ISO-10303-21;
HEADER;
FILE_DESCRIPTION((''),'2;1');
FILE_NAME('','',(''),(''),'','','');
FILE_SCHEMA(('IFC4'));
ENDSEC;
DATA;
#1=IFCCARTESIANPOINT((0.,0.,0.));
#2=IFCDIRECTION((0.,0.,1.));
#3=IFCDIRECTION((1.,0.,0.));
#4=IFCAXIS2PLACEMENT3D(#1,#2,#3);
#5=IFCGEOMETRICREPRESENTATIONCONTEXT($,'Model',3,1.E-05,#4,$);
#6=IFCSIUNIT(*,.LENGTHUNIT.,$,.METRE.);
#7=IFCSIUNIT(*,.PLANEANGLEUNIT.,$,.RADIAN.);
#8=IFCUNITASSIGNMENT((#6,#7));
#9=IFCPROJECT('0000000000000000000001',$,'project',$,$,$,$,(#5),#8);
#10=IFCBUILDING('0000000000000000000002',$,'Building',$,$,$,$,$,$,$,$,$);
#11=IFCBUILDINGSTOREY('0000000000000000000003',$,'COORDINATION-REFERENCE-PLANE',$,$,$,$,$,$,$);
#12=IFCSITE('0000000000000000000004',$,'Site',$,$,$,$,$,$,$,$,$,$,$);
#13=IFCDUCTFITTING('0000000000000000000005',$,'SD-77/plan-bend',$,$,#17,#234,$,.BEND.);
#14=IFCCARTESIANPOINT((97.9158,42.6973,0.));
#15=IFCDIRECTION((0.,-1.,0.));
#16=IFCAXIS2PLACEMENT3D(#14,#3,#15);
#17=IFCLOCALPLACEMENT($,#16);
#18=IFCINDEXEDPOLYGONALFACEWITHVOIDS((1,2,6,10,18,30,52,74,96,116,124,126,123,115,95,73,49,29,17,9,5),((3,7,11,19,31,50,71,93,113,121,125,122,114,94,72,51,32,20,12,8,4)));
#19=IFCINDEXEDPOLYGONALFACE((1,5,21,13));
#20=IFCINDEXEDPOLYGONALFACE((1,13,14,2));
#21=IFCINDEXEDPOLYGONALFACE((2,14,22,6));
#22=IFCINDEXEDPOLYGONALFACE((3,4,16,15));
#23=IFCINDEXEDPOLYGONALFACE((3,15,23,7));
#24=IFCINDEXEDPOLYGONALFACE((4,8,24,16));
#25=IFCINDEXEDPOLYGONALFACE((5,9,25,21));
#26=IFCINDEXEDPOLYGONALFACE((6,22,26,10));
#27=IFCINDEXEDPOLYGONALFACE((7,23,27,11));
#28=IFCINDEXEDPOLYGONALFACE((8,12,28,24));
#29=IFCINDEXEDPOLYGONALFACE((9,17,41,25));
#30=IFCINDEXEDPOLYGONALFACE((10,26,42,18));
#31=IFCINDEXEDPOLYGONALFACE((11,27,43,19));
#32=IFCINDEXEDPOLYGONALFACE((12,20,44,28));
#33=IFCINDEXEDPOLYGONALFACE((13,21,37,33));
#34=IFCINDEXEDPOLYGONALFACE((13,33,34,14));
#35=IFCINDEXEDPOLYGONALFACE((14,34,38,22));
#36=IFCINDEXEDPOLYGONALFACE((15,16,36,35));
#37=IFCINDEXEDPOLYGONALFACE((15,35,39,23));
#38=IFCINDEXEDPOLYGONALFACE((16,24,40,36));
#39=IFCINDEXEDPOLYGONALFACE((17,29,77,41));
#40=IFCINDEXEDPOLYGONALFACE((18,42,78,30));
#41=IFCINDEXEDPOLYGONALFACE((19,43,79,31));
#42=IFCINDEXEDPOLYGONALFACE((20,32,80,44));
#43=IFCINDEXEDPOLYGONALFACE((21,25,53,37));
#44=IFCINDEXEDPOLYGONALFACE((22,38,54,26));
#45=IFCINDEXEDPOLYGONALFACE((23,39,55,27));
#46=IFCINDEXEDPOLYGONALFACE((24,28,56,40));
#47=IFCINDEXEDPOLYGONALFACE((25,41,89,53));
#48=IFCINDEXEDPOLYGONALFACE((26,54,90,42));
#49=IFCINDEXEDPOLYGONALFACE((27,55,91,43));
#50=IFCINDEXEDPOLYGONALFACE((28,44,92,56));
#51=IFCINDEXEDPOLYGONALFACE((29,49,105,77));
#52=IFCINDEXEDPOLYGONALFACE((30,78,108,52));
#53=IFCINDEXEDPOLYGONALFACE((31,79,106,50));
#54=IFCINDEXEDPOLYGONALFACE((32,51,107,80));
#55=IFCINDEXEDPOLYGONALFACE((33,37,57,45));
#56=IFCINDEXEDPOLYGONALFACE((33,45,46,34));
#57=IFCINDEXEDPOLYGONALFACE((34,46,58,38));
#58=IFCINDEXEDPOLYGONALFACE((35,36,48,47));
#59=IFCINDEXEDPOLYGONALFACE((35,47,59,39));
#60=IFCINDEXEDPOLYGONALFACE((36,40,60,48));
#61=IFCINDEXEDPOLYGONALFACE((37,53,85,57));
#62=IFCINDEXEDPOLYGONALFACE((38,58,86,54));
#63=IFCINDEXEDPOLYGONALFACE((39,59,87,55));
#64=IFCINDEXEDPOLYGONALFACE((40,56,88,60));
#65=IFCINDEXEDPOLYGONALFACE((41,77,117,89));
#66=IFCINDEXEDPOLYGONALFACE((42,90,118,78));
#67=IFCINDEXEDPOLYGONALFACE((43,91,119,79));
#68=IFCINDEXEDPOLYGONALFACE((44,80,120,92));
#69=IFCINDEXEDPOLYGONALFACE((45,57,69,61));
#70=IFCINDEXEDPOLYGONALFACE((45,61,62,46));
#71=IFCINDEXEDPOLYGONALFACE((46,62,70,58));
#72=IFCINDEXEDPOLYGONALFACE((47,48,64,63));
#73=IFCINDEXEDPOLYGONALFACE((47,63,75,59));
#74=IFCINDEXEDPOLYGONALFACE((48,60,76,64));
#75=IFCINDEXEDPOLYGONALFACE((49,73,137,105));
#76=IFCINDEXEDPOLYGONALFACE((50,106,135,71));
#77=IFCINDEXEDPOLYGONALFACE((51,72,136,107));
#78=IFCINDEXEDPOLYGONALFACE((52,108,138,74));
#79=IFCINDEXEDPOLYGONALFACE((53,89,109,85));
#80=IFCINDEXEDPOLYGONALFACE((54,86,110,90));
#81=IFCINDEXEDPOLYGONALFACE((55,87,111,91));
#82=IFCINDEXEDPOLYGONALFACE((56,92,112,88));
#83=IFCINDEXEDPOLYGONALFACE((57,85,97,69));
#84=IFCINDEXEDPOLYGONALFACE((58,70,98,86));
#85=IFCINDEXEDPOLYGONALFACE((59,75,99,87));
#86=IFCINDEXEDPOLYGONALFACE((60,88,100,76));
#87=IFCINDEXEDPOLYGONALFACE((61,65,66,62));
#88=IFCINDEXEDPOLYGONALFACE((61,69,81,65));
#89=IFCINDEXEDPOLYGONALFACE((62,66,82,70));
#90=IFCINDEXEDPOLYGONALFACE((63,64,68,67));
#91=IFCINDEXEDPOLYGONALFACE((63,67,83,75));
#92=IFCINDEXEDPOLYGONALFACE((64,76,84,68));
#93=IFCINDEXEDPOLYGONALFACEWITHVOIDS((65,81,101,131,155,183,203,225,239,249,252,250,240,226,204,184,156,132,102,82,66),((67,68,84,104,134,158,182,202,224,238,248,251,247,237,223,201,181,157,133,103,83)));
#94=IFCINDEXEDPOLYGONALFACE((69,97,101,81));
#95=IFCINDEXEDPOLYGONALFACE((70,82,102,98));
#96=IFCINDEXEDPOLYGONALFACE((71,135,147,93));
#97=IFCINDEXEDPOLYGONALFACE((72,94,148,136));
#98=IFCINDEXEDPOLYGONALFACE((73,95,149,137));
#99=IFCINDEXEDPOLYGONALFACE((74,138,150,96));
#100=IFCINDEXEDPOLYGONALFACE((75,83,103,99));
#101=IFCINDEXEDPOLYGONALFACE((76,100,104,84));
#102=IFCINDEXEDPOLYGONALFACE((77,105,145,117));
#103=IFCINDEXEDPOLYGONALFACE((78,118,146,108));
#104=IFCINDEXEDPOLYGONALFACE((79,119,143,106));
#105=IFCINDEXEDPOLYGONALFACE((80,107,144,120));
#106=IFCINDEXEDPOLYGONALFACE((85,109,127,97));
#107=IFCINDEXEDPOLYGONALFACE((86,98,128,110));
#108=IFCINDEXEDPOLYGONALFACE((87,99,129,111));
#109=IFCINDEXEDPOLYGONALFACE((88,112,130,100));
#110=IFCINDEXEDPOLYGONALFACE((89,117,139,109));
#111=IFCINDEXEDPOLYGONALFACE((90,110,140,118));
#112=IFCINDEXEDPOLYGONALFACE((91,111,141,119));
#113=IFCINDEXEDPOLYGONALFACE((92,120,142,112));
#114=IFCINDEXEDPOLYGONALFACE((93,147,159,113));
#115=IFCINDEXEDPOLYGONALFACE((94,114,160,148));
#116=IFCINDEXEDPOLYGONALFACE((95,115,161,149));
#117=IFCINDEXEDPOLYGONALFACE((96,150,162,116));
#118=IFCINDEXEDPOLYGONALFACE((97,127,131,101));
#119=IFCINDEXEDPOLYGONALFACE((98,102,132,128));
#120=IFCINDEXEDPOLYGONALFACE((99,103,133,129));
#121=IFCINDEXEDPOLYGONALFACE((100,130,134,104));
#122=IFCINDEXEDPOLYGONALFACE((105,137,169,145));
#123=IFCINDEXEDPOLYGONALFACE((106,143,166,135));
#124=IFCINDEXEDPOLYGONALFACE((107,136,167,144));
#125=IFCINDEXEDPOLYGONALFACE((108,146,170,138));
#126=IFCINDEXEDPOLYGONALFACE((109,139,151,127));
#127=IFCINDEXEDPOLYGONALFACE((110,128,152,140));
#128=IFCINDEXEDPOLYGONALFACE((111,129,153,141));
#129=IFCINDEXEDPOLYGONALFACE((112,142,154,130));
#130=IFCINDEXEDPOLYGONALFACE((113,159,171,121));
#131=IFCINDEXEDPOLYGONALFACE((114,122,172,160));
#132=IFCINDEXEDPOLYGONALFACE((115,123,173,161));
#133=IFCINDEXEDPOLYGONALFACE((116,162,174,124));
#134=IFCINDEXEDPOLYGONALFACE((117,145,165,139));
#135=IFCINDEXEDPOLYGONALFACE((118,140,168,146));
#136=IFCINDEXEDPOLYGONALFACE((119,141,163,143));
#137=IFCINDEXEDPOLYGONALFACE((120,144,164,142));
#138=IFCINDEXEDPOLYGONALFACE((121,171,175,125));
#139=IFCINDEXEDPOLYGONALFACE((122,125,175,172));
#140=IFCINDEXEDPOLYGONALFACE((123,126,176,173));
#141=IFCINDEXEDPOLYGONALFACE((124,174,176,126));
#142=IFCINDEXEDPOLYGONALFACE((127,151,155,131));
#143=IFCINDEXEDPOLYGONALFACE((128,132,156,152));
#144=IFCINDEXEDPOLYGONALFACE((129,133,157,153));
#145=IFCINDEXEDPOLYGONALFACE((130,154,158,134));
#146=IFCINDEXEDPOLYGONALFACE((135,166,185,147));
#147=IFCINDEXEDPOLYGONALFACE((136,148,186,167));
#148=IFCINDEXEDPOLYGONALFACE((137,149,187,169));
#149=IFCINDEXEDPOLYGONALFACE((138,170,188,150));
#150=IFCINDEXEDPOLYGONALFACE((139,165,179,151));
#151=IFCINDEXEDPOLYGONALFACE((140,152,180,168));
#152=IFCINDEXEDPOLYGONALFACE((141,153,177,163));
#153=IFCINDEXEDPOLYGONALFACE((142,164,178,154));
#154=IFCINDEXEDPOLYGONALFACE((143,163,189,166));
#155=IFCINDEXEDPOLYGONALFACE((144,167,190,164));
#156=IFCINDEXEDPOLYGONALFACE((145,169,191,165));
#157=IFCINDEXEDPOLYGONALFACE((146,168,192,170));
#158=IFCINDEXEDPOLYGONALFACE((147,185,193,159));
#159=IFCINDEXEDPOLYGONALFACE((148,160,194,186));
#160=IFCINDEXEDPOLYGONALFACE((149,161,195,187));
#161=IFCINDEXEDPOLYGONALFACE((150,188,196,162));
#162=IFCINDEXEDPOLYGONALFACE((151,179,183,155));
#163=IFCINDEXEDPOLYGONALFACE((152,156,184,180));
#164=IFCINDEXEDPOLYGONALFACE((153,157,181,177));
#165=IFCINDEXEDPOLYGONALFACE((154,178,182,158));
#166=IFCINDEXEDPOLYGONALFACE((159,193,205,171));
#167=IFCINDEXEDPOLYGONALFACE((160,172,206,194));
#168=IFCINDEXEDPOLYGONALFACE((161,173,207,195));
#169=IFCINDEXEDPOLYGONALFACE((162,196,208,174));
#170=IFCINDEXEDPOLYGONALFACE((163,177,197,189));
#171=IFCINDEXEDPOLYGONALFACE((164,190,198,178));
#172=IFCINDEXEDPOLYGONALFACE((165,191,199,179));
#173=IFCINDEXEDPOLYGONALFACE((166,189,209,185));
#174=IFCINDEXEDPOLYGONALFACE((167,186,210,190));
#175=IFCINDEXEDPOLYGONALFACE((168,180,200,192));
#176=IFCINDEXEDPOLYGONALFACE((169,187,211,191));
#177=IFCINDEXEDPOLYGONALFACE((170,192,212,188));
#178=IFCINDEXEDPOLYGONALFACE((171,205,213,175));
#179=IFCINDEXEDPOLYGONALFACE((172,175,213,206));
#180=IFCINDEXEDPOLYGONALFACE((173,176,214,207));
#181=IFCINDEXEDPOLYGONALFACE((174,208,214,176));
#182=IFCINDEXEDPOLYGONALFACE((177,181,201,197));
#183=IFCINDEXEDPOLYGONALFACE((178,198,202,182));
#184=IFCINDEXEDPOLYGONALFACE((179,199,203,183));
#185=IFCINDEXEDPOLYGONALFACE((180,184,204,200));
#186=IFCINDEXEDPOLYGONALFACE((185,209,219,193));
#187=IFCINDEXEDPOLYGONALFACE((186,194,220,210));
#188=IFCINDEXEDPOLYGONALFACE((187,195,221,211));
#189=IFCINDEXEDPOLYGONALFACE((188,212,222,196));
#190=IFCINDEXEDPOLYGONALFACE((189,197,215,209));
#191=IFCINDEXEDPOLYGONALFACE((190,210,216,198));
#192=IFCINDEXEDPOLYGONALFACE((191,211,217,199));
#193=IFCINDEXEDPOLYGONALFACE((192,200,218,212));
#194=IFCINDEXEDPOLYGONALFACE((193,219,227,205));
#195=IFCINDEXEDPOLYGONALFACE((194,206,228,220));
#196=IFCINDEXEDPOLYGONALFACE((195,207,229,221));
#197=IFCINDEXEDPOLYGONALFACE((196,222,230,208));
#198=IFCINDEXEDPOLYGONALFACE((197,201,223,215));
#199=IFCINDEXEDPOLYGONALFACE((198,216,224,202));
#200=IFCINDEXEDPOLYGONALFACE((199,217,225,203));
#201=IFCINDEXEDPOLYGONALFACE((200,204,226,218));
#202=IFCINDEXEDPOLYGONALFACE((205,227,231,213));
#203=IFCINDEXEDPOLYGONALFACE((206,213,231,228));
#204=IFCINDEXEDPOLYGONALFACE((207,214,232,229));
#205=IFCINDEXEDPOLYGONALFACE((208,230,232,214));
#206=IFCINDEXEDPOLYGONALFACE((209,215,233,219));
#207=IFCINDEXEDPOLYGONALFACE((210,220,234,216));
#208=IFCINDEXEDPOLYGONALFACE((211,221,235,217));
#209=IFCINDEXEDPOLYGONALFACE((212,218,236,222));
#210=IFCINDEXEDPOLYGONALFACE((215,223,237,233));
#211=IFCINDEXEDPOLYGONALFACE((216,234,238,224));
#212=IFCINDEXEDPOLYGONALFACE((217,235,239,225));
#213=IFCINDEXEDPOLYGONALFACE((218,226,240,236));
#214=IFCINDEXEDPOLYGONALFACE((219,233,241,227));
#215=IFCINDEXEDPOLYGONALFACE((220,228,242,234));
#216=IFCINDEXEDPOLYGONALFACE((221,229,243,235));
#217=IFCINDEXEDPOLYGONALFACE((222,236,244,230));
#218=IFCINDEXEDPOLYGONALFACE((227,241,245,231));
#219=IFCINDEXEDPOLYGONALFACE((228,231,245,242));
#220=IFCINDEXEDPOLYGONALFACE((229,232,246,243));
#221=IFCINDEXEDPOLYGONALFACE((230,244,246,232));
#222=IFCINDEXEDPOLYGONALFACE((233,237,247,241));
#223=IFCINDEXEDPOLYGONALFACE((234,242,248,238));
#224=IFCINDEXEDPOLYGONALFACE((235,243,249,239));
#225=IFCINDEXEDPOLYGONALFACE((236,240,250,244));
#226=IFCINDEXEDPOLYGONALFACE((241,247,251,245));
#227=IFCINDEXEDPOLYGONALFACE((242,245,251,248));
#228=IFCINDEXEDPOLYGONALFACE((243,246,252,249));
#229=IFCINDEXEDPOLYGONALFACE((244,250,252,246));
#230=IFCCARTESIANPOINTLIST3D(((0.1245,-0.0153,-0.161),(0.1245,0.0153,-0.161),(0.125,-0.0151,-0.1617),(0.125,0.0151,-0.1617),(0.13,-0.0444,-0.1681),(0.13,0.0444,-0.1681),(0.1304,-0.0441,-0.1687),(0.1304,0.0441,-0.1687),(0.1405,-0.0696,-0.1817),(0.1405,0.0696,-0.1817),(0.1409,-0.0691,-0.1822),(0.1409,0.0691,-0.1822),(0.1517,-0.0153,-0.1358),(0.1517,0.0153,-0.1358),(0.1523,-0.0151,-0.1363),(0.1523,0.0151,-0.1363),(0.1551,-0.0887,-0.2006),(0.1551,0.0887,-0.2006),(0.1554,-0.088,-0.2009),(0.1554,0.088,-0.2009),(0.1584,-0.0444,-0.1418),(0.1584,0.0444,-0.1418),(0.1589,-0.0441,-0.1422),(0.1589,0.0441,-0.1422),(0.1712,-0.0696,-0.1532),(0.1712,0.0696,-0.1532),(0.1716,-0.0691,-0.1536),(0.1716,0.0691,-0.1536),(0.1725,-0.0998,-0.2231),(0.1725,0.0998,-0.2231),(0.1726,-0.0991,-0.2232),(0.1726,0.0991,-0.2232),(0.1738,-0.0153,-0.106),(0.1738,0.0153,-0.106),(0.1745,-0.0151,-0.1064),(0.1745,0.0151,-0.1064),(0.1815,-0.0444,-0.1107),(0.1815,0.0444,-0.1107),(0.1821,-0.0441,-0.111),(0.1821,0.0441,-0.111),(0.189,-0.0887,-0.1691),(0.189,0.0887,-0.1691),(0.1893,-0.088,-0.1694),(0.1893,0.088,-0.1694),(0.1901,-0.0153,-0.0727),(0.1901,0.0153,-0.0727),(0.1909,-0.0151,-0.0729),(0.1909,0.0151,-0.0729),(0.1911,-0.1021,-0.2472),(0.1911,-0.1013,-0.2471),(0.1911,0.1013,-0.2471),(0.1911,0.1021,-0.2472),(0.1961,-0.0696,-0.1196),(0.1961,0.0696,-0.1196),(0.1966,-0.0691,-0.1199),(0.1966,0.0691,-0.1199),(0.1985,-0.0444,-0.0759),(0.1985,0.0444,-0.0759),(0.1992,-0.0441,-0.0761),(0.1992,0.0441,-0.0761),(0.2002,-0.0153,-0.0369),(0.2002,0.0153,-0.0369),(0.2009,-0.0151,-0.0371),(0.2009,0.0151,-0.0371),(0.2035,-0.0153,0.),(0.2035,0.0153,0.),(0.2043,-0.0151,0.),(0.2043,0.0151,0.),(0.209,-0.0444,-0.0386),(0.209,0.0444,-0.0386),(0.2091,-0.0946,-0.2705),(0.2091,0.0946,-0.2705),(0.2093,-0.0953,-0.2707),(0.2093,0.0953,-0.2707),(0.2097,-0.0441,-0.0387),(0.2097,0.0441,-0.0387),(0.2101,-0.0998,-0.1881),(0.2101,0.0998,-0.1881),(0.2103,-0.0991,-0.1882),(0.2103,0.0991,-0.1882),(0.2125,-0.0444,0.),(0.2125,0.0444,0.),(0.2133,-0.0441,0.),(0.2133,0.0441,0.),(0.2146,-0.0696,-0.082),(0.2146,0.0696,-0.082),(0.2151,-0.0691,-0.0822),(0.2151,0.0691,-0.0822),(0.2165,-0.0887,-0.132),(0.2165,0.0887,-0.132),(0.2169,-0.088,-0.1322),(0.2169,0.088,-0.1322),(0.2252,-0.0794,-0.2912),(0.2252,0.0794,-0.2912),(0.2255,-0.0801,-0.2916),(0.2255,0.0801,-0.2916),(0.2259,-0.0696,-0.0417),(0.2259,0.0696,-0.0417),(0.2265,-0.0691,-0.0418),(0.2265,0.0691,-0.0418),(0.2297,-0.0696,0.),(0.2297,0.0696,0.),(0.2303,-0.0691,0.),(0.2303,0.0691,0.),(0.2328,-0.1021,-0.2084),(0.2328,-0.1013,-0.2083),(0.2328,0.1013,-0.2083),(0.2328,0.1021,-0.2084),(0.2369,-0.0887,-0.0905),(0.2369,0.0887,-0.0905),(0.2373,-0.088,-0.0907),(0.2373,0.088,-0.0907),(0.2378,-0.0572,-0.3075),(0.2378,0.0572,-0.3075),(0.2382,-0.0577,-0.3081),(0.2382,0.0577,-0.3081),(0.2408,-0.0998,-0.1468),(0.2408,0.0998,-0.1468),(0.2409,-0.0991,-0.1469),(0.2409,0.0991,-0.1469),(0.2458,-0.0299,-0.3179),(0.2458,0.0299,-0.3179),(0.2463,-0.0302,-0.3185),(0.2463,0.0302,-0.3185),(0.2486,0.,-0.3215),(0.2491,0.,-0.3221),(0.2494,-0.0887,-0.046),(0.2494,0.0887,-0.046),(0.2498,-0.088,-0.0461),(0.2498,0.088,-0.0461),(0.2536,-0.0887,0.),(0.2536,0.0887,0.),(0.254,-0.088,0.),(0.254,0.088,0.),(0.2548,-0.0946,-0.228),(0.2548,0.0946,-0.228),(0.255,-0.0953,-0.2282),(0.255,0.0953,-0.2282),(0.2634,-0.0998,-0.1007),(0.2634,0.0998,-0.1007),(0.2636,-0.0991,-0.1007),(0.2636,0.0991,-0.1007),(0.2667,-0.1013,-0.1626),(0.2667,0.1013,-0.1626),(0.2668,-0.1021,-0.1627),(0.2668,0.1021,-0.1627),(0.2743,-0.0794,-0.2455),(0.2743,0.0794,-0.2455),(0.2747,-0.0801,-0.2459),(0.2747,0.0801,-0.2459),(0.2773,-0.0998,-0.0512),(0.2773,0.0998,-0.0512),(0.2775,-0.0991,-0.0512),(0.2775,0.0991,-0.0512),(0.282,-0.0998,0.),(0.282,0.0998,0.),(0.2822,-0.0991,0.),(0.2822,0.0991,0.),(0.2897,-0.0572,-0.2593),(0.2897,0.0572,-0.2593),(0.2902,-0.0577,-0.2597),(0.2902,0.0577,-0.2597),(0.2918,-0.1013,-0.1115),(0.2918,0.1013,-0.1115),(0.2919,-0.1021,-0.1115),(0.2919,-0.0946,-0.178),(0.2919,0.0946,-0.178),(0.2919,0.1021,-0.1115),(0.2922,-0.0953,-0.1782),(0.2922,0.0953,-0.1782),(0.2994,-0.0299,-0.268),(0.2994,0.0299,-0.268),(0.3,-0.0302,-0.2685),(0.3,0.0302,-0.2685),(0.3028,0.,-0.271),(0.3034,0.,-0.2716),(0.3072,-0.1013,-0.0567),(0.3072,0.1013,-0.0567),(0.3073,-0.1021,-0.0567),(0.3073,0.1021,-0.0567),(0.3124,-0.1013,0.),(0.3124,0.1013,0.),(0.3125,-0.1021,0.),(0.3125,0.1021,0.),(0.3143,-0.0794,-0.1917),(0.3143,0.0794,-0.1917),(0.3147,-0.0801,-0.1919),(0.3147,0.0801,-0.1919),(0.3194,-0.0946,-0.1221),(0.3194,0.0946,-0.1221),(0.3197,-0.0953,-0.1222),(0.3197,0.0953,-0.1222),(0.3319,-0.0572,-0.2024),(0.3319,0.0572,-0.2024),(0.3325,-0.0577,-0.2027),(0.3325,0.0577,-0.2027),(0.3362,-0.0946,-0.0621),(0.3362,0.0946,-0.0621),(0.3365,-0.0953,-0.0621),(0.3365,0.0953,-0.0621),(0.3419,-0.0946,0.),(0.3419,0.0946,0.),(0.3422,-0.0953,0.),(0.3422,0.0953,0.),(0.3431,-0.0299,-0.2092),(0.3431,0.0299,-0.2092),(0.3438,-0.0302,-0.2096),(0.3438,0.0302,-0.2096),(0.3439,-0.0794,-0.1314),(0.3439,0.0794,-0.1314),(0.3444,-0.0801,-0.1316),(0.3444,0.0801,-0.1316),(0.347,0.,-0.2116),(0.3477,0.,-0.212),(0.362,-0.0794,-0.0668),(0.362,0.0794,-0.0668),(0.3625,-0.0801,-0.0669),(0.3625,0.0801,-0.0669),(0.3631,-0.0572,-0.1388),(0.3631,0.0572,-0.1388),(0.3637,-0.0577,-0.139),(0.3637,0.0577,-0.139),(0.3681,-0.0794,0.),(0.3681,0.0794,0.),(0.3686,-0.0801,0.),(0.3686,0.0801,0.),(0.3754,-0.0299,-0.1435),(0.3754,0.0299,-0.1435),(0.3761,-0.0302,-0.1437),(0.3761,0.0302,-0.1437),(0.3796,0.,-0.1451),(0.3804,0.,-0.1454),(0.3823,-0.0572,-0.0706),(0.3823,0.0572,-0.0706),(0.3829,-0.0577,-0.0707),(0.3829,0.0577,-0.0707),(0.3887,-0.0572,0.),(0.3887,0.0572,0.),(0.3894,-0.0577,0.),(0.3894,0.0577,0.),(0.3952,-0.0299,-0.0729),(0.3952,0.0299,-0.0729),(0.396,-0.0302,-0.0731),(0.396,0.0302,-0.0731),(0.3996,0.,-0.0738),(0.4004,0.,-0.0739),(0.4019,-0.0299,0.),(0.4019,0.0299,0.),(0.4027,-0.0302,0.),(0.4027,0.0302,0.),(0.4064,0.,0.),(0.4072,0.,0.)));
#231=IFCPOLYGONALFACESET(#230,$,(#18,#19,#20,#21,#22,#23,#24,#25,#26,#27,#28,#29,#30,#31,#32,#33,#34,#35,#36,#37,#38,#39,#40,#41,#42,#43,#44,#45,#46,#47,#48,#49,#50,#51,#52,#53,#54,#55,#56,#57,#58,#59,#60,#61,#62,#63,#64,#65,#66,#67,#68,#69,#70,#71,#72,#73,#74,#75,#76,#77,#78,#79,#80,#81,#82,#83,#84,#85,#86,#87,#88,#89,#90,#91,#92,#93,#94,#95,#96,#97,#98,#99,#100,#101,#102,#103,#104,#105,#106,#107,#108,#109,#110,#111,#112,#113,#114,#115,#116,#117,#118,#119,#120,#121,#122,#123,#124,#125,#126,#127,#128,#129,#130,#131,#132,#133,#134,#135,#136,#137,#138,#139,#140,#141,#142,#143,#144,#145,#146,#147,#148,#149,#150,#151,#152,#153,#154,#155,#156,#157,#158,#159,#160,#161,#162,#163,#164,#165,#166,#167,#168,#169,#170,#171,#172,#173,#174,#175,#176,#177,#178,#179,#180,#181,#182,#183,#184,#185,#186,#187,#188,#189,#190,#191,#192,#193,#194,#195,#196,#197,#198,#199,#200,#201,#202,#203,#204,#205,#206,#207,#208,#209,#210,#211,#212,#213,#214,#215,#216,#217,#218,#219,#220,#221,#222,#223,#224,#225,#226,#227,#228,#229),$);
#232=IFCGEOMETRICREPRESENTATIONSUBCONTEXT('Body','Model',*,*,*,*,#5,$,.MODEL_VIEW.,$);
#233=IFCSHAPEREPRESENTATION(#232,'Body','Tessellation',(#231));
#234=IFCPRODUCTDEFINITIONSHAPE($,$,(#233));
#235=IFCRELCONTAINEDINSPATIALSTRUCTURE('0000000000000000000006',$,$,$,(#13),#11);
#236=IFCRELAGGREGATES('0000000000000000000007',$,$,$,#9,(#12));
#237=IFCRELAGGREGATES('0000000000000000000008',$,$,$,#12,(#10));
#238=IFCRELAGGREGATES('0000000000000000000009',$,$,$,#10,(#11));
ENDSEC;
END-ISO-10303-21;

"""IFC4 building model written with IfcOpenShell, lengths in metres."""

from ifc_helpers import new_model, entity, si_unit, frame, origin_with_axes, place, context, subcontext, project, spatial, element, save


model = new_model("IFC4")

# Units and contexts
model_context = context("Model", 3, precision=1e-05, world=origin_with_axes())
body_context_1 = subcontext(model_context, "Body", "Model", "MODEL_VIEW")
ifc_project = project(units=[si_unit("LENGTHUNIT", "METRE"), si_unit("PLANEANGLEUNIT", "RADIAN")], contexts=[model_context])

# Site, building, storey
site = spatial("IfcSite", under=ifc_project, Name="Site")
building = spatial("IfcBuilding", under=site, Name="Building")
storey = spatial("IfcBuildingStorey", under=building, Name="COORDINATION-REFERENCE-PLANE")

# Duct fitting
duct_fitting_1_placement = place(None, frame((97.9158, 42.6973, 0.0), z_axis=(1.0, 0.0, 0.0), x_axis=(0.0, -1.0, 0.0)))
element("IfcDuctFitting", 1, at=duct_fitting_1_placement, inside=storey, Name="SD-77/plan-bend", PredefinedType="BEND", context=body_context_1, shape_type="SweptSolid", body=[
    entity("IfcRevolvedAreaSolid", entity("IfcCircleHollowProfileDef", "AREA", None, entity("IfcAxis2Placement2D", entity("IfcCartesianPoint", [0.3048, 0.0])), 0.1024, 0.0008), entity("IfcAxis2Placement3D", entity("IfcCartesianPoint", [0.0, 0.0, 0.0]), entity("IfcDirection", [0.0, 0.0, 1.0]), entity("IfcDirection", [1.0, 0.0, 0.0])), entity("IfcAxis1Placement", entity("IfcCartesianPoint", [0.0, 0.0, 0.0]), entity("IfcDirection", [0.0, 1.0, 0.0])), 0.912619),
])

save(model, "model.ifc")
